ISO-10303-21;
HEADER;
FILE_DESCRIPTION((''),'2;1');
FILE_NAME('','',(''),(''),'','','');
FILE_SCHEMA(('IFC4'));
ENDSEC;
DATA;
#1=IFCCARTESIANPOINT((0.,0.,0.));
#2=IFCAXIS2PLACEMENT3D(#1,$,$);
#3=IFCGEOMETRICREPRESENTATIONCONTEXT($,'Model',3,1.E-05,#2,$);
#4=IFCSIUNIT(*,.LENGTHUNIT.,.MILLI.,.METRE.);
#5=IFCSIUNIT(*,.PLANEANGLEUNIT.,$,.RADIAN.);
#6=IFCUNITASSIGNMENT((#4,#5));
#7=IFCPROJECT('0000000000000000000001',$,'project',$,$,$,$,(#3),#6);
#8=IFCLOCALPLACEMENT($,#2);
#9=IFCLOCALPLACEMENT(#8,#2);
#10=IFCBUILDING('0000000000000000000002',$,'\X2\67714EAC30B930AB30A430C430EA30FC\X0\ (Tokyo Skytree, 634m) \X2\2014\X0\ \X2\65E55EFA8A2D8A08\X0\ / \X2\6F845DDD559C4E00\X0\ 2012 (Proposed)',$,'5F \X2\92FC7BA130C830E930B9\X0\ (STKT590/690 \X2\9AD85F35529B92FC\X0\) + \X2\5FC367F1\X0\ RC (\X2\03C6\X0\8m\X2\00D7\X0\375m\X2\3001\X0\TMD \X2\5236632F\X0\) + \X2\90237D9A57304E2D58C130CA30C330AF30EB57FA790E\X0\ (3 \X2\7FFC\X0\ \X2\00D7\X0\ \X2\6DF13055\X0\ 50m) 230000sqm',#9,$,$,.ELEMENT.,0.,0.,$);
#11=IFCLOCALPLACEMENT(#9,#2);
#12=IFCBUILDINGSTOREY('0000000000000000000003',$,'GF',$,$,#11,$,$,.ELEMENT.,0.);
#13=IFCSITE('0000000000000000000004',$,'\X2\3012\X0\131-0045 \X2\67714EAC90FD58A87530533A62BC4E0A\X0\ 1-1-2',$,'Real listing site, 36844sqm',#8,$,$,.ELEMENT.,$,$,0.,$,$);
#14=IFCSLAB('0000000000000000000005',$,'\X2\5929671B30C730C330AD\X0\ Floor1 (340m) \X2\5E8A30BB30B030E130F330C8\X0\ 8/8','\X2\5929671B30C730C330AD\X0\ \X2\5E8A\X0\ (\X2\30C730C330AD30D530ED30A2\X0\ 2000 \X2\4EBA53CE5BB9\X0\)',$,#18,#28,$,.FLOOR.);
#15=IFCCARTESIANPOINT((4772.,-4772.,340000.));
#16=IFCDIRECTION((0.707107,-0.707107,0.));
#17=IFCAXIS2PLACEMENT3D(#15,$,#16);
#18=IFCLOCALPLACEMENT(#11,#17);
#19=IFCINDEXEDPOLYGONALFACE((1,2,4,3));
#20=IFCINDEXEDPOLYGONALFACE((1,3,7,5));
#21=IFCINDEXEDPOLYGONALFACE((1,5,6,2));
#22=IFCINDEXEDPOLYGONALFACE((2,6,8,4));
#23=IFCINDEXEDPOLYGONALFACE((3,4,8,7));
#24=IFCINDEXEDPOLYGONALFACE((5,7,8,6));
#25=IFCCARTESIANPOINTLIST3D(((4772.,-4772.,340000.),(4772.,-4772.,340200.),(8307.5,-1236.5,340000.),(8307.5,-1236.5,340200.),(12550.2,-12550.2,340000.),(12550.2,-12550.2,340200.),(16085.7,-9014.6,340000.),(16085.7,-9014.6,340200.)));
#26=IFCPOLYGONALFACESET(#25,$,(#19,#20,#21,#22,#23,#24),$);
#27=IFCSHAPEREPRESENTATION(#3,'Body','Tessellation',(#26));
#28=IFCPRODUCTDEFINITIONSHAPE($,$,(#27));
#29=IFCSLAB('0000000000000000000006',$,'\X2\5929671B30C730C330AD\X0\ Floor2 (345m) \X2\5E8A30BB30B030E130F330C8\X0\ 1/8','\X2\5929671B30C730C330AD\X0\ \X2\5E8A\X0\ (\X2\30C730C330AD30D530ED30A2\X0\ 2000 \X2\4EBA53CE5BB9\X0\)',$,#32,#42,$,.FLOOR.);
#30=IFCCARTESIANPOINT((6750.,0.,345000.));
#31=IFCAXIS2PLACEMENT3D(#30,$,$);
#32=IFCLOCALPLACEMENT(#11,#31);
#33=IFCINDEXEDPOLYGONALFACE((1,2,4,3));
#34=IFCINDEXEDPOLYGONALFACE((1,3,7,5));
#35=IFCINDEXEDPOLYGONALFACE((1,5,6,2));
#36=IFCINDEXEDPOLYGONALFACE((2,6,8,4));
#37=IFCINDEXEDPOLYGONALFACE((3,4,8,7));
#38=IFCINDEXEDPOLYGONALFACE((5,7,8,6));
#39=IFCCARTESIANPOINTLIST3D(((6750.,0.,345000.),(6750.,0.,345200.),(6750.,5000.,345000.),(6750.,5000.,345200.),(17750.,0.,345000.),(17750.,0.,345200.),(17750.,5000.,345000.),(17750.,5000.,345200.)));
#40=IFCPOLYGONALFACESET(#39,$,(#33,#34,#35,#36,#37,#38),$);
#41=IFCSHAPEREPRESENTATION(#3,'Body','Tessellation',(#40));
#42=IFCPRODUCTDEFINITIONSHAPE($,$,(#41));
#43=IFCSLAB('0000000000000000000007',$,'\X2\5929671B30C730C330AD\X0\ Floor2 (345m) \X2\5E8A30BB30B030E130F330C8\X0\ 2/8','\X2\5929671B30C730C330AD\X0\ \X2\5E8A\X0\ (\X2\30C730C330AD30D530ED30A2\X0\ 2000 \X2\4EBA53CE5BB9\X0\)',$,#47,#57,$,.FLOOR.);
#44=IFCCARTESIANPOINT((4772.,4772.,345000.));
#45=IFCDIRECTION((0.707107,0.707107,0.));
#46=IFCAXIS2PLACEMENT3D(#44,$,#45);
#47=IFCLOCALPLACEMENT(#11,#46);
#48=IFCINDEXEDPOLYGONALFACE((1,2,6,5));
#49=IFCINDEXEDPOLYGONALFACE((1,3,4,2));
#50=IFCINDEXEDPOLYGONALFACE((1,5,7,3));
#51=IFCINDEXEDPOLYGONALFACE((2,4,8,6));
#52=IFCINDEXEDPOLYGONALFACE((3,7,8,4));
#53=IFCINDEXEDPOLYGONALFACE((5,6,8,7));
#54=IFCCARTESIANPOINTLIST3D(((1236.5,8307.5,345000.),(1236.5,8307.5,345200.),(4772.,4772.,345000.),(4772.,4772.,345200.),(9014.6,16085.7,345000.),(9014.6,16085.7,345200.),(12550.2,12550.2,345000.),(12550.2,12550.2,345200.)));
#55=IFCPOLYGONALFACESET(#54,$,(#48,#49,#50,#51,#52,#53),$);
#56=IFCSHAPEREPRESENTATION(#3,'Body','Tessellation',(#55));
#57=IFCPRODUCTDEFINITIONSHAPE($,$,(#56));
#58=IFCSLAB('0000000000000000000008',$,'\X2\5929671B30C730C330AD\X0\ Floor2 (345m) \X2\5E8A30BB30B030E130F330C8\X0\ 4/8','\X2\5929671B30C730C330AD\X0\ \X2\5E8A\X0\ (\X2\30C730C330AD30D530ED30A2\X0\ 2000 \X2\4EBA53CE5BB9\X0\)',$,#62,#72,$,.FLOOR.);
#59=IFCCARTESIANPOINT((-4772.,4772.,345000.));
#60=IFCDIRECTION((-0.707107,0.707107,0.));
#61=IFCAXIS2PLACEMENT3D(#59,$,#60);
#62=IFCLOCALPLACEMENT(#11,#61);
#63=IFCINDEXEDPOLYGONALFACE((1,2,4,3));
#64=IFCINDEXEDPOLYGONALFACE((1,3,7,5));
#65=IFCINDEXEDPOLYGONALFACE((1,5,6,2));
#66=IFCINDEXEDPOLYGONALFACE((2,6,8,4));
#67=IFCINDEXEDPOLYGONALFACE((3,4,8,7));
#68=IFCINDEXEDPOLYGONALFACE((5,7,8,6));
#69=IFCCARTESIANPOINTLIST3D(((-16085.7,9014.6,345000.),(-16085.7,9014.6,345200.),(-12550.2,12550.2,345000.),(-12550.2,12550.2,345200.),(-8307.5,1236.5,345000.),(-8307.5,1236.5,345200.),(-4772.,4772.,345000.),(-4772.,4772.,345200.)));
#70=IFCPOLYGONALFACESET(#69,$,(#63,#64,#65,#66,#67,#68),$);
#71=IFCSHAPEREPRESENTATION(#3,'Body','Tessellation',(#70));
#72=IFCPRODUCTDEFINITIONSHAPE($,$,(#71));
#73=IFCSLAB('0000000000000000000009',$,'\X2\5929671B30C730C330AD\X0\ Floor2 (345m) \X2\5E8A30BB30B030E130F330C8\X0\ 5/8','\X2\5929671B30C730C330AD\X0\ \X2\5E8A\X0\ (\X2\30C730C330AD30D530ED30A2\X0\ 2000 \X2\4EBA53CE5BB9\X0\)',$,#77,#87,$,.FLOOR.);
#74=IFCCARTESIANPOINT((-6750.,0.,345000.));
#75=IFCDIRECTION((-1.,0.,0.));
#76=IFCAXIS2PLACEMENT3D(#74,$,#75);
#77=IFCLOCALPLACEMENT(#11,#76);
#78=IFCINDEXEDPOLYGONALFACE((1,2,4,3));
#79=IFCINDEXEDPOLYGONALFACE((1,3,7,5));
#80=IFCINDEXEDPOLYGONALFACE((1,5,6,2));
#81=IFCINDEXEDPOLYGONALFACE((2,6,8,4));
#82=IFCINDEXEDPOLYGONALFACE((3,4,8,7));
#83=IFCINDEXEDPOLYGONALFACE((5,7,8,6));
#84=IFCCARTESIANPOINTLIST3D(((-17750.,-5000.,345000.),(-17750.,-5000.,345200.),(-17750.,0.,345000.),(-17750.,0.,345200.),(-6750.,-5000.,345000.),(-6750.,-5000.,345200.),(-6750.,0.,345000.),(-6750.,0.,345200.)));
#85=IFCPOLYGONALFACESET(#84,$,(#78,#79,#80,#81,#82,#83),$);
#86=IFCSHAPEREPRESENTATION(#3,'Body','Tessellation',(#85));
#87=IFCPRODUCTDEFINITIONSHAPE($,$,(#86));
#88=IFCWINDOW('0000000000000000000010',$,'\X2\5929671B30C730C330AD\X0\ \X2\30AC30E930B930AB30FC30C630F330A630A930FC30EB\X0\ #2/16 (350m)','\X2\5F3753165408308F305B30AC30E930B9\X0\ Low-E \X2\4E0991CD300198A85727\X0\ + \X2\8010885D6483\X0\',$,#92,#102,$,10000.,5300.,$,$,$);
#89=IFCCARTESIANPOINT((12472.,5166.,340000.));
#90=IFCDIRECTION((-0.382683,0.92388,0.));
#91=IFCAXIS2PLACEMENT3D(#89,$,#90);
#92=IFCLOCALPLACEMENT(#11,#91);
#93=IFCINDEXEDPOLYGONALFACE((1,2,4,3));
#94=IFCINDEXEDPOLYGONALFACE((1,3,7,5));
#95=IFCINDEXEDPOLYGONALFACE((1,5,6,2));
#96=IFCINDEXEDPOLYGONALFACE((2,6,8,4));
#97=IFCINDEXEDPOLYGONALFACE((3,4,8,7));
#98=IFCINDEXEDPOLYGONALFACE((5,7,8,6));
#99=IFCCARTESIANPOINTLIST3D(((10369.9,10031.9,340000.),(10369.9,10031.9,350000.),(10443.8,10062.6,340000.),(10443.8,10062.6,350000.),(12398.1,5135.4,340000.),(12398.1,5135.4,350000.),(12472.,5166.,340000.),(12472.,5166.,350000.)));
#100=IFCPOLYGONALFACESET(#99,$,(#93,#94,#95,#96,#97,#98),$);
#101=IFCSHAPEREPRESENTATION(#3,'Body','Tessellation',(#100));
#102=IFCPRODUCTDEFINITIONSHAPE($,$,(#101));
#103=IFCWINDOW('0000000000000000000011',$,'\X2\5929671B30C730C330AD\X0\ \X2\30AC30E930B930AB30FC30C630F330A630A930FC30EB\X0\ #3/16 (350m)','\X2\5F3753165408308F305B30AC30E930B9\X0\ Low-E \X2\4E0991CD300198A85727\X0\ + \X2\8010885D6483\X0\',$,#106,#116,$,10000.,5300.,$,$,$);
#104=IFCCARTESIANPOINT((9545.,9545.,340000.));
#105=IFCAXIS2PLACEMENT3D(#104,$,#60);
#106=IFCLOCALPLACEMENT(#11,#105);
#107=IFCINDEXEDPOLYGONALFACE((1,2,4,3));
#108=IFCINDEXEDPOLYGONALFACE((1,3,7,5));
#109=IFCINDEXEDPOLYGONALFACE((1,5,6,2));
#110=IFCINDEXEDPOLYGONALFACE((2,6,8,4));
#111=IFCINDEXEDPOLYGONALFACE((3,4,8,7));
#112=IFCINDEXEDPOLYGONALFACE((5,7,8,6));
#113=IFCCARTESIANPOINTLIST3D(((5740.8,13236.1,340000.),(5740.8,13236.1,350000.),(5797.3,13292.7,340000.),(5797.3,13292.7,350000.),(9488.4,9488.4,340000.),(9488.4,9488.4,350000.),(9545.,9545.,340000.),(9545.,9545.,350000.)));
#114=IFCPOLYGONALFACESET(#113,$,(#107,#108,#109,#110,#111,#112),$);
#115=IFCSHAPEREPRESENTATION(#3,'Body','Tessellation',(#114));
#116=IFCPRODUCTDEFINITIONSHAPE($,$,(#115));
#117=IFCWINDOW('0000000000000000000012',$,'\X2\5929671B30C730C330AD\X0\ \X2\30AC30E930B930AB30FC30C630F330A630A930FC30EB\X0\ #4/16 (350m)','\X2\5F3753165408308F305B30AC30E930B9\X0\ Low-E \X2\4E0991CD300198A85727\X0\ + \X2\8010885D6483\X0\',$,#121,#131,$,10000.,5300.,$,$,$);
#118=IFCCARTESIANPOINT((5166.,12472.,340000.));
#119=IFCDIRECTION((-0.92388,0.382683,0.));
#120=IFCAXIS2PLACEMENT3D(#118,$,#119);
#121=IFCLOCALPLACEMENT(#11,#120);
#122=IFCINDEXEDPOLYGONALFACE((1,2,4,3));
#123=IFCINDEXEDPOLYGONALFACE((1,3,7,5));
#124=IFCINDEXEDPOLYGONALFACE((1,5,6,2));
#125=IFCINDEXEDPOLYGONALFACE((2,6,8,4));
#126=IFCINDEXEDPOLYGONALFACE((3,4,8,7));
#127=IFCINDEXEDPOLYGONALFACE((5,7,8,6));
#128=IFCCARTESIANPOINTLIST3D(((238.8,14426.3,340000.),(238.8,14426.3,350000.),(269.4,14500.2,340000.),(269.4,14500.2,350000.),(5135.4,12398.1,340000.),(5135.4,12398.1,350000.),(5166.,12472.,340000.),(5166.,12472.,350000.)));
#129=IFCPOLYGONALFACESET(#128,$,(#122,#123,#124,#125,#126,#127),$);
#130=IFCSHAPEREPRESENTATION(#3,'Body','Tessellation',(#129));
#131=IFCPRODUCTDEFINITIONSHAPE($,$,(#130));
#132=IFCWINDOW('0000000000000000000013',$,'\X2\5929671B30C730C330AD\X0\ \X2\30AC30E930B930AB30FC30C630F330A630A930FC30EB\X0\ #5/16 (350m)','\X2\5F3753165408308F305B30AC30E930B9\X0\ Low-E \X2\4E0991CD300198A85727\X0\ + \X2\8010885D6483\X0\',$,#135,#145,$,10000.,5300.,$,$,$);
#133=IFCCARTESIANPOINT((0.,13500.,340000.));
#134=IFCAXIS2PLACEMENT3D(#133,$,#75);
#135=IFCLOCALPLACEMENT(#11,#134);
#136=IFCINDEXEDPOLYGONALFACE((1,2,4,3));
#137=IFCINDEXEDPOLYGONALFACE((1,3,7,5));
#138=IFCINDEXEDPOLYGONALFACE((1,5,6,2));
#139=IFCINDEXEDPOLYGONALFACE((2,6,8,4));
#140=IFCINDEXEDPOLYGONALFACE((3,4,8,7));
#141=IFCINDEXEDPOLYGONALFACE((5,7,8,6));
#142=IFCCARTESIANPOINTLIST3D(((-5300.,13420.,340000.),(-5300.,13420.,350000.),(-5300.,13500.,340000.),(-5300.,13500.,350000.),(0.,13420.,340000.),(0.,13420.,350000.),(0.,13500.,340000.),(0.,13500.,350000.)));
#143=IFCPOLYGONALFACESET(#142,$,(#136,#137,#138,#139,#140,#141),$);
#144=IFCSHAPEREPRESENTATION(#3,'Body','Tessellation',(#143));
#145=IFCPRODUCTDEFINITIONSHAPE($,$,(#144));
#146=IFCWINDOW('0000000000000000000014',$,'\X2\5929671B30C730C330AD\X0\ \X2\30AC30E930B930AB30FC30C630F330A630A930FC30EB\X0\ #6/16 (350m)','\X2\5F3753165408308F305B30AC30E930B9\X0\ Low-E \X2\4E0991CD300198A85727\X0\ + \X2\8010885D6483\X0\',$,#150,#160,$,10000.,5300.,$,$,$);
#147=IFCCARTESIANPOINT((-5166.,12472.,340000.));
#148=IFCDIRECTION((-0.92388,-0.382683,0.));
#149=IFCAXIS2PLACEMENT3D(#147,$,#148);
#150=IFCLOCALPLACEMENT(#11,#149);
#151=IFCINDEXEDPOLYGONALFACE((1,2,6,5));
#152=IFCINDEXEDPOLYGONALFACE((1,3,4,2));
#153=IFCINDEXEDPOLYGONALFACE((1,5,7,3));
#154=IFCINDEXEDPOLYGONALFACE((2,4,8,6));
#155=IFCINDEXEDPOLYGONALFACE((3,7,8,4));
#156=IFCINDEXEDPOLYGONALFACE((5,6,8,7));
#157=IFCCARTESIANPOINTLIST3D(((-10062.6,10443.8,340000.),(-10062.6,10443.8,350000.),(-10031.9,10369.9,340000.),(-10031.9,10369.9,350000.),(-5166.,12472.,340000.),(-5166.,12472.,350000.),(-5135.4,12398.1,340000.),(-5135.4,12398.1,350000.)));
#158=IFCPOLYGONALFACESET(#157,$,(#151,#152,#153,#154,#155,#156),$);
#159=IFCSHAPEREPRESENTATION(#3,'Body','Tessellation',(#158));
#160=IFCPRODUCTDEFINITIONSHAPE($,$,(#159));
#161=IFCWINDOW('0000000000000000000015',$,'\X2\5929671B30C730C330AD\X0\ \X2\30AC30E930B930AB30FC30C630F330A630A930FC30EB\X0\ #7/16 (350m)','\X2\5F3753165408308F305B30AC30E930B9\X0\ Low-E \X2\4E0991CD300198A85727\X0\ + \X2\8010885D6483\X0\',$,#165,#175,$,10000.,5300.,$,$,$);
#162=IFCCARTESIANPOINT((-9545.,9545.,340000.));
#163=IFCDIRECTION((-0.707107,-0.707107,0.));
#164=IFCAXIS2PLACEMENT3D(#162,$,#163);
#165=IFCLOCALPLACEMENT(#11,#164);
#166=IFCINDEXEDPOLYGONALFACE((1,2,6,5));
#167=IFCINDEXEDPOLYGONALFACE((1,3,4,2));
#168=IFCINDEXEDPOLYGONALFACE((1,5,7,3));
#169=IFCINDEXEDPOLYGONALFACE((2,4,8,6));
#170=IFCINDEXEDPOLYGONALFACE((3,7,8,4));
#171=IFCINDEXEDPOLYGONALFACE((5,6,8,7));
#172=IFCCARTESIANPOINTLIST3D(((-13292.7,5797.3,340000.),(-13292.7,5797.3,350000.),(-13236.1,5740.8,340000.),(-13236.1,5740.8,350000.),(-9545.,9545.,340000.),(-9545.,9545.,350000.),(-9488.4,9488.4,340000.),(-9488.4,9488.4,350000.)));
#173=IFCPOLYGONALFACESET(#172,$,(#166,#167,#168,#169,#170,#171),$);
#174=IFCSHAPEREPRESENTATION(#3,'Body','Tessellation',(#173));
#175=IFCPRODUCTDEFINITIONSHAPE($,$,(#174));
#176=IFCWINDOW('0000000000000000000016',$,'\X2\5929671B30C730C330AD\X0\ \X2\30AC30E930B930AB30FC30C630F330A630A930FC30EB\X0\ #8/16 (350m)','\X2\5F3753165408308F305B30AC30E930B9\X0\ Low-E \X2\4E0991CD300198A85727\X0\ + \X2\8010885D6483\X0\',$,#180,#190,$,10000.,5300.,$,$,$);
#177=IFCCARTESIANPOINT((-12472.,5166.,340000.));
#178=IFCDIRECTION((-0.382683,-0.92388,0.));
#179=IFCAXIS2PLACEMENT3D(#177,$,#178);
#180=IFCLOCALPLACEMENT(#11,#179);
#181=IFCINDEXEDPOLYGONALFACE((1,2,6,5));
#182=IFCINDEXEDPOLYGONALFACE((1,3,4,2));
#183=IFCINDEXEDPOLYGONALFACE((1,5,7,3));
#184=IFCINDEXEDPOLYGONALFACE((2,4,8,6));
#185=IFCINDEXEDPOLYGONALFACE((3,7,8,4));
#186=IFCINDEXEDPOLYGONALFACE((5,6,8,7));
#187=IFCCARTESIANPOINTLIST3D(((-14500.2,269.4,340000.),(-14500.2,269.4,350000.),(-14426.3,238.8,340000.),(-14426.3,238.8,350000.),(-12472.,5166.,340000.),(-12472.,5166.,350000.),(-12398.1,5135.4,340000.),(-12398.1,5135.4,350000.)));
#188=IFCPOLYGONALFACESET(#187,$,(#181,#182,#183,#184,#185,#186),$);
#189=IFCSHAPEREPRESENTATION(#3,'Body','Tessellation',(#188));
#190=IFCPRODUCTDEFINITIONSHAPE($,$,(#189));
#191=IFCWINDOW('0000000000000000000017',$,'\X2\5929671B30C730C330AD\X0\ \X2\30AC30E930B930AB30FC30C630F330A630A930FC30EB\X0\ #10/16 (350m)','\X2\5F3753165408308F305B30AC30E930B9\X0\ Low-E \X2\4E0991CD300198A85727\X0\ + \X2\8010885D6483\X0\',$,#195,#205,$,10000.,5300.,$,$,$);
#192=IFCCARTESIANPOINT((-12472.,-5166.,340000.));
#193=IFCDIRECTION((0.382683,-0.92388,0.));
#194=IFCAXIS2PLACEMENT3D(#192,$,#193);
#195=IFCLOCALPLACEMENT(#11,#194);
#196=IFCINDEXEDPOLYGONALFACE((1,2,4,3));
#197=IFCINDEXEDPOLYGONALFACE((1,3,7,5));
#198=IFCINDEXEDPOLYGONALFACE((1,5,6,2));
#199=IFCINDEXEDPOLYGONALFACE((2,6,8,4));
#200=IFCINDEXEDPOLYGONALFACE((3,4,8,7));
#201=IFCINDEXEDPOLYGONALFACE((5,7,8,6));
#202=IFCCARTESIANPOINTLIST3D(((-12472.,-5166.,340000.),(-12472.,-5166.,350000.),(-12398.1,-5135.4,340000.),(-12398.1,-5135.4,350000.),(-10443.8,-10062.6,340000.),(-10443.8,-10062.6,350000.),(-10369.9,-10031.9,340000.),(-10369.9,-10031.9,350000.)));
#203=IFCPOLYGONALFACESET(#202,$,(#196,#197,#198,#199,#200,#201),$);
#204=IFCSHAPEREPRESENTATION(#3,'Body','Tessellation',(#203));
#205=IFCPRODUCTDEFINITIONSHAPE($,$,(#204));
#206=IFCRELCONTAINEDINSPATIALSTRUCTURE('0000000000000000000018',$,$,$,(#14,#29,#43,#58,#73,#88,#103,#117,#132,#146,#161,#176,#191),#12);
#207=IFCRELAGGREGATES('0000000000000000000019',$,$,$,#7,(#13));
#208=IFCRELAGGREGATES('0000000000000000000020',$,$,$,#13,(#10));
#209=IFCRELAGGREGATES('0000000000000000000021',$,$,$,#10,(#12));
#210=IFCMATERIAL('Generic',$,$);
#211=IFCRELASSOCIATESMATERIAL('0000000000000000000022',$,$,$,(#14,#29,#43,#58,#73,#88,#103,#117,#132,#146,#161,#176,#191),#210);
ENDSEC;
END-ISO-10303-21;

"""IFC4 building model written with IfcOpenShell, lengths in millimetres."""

from ifc_helpers import new_model, si_unit, frame, frame_2d, origin, place, context, project, spatial, rectangle, extrude, material, element, save


model = new_model("IFC4")

# Units and contexts
model_context = context("Model", 3, precision=1e-05, world=origin())
ifc_project = project(units=[si_unit("LENGTHUNIT", "METRE", prefix="MILLI"), si_unit("PLANEANGLEUNIT", "RADIAN")], contexts=[model_context])

# Site, building, storey
site_placement = place(None, origin())
site = spatial("IfcSite", under=ifc_project, at=site_placement, Name="〒131-0045 東京都墨田区押上 1-1-2", ObjectType="Real listing site, 36844sqm", CompositionType="ELEMENT", RefElevation=0.0)
building_placement = place(site_placement, origin())
building = spatial("IfcBuilding", under=site, at=building_placement, Name="東京スカイツリー (Tokyo Skytree, 634m) — 日建設計 / 澄川喜一 2012 (Proposed)", ObjectType="5F 鋼管トラス (STKT590/690 高張力鋼) + 心柱 RC (φ8m×375m、TMD 制振) + 連続地中壁ナックル基礎 (3 翼 × 深さ 50m) 230000sqm", CompositionType="ELEMENT", ElevationOfRefHeight=0.0, ElevationOfTerrain=0.0)
storey_placement = place(building_placement, origin())
storey = spatial("IfcBuildingStorey", under=building, at=storey_placement, Name="GF", CompositionType="ELEMENT", Elevation=0.0)

# Slabs
ifc_material = material(Name="Generic")
slab_1_placement = place(storey_placement, frame((4772.0, -4772.0, 340000.0), x_axis=(0.707107, -0.707107, 0.0)))
element("IfcSlab", 1, at=slab_1_placement, inside=storey, material=ifc_material, Name="天望デッキ Floor1 (340m) 床セグメント 8/8", Description="天望デッキ 床 (デッキフロア 2000 人収容)", PredefinedType="FLOOR", context=model_context, shape_type="SweptSolid", body=[
    extrude(rectangle(XDim=11000.0, YDim=5000.0, at=frame_2d((5500.0, 2500.0))), frame((4772.0, -4772.0, 340000.0), x_axis=(0.707107, -0.707107, 0.0)), (0.0, 0.0, 1.0), 200.0),
])
slab_2_placement = place(storey_placement, frame((6750.0, 0.0, 345000.0)))
element("IfcSlab", 2, at=slab_2_placement, inside=storey, material=ifc_material, Name="天望デッキ Floor2 (345m) 床セグメント 1/8", Description="天望デッキ 床 (デッキフロア 2000 人収容)", PredefinedType="FLOOR", context=model_context, shape_type="SweptSolid", body=[
    extrude(rectangle(XDim=11000.0, YDim=5000.0, at=frame_2d((5500.0, 2500.0))), frame((6750.0, 0.0, 345000.0)), (0.0, 0.0, 1.0), 200.0),
])
slab_3_placement = place(storey_placement, frame((4772.0, 4772.0, 345000.0), x_axis=(0.707107, 0.707107, 0.0)))
element("IfcSlab", 3, at=slab_3_placement, inside=storey, material=ifc_material, Name="天望デッキ Floor2 (345m) 床セグメント 2/8", Description="天望デッキ 床 (デッキフロア 2000 人収容)", PredefinedType="FLOOR", context=model_context, shape_type="SweptSolid", body=[
    extrude(rectangle(XDim=11000.0, YDim=5000.0, at=frame_2d((5500.0, 2500.0))), frame((4772.0, 4772.0, 345000.0), x_axis=(0.707107, 0.707107, 0.0)), (0.0, 0.0, 1.0), 200.0),
])
slab_4_placement = place(storey_placement, frame((-4772.0, 4772.0, 345000.0), x_axis=(-0.707107, 0.707107, 0.0)))
element("IfcSlab", 4, at=slab_4_placement, inside=storey, material=ifc_material, Name="天望デッキ Floor2 (345m) 床セグメント 4/8", Description="天望デッキ 床 (デッキフロア 2000 人収容)", PredefinedType="FLOOR", context=model_context, shape_type="SweptSolid", body=[
    extrude(rectangle(XDim=11000.0, YDim=5000.0, at=frame_2d((5500.0, 2500.0))), frame((-4772.0, 4772.0, 345000.0), x_axis=(-0.707107, 0.707107, 0.0)), (0.0, 0.0, 1.0), 200.0),
])
slab_5_placement = place(storey_placement, frame((-6750.0, 0.0, 345000.0), x_axis=(-1.0, 0.0, 0.0)))
element("IfcSlab", 5, at=slab_5_placement, inside=storey, material=ifc_material, Name="天望デッキ Floor2 (345m) 床セグメント 5/8", Description="天望デッキ 床 (デッキフロア 2000 人収容)", PredefinedType="FLOOR", context=model_context, shape_type="SweptSolid", body=[
    extrude(rectangle(XDim=11000.0, YDim=5000.0, at=frame_2d((5500.0, 2500.0))), frame((-6750.0, 0.0, 345000.0), x_axis=(-1.0, 0.0, 0.0)), (0.0, 0.0, 1.0), 200.0),
])

# Windows
window_1_placement = place(storey_placement, frame((12472.0, 5166.0, 340000.0), x_axis=(-0.382683, 0.92388, 0.0)))
element("IfcWindow", 6, at=window_1_placement, inside=storey, material=ifc_material, Name="天望デッキ ガラスカーテンウォール #2/16 (350m)", Description="強化合わせガラス Low-E 三重、風圧 + 耐衝撃", OverallHeight=10000.0, OverallWidth=5300.0, context=model_context, shape_type="SweptSolid", body=[
    extrude(rectangle(XDim=5300.0, YDim=80.0, at=frame_2d((2650.0, 40.0))), frame((12472.0, 5166.0, 340000.0), x_axis=(-0.382683, 0.92388, 0.0)), (0.0, 0.0, 1.0), 10000.0),
])
window_2_placement = place(storey_placement, frame((9545.0, 9545.0, 340000.0), x_axis=(-0.707107, 0.707107, 0.0)))
element("IfcWindow", 7, at=window_2_placement, inside=storey, material=ifc_material, Name="天望デッキ ガラスカーテンウォール #3/16 (350m)", Description="強化合わせガラス Low-E 三重、風圧 + 耐衝撃", OverallHeight=10000.0, OverallWidth=5300.0, context=model_context, shape_type="SweptSolid", body=[
    extrude(rectangle(XDim=5300.0, YDim=80.0, at=frame_2d((2650.0, 40.0))), frame((9545.0, 9545.0, 340000.0), x_axis=(-0.707107, 0.707107, 0.0)), (0.0, 0.0, 1.0), 10000.0),
])
window_3_placement = place(storey_placement, frame((5166.0, 12472.0, 340000.0), x_axis=(-0.92388, 0.382683, 0.0)))
element("IfcWindow", 8, at=window_3_placement, inside=storey, material=ifc_material, Name="天望デッキ ガラスカーテンウォール #4/16 (350m)", Description="強化合わせガラス Low-E 三重、風圧 + 耐衝撃", OverallHeight=10000.0, OverallWidth=5300.0, context=model_context, shape_type="SweptSolid", body=[
    extrude(rectangle(XDim=5300.0, YDim=80.0, at=frame_2d((2650.0, 40.0))), frame((5166.0, 12472.0, 340000.0), x_axis=(-0.92388, 0.382683, 0.0)), (0.0, 0.0, 1.0), 10000.0),
])
window_4_placement = place(storey_placement, frame((0.0, 13500.0, 340000.0), x_axis=(-1.0, 0.0, 0.0)))
element("IfcWindow", 9, at=window_4_placement, inside=storey, material=ifc_material, Name="天望デッキ ガラスカーテンウォール #5/16 (350m)", Description="強化合わせガラス Low-E 三重、風圧 + 耐衝撃", OverallHeight=10000.0, OverallWidth=5300.0, context=model_context, shape_type="SweptSolid", body=[
    extrude(rectangle(XDim=5300.0, YDim=80.0, at=frame_2d((2650.0, 40.0))), frame((0.0, 13500.0, 340000.0), x_axis=(-1.0, 0.0, 0.0)), (0.0, 0.0, 1.0), 10000.0),
])
window_5_placement = place(storey_placement, frame((-5166.0, 12472.0, 340000.0), x_axis=(-0.92388, -0.382683, 0.0)))
element("IfcWindow", 10, at=window_5_placement, inside=storey, material=ifc_material, Name="天望デッキ ガラスカーテンウォール #6/16 (350m)", Description="強化合わせガラス Low-E 三重、風圧 + 耐衝撃", OverallHeight=10000.0, OverallWidth=5300.0, context=model_context, shape_type="SweptSolid", body=[
    extrude(rectangle(XDim=5300.0, YDim=80.0, at=frame_2d((2650.0, 40.0))), frame((-5166.0, 12472.0, 340000.0), x_axis=(-0.92388, -0.382683, 0.0)), (0.0, 0.0, 1.0), 10000.0),
])
window_6_placement = place(storey_placement, frame((-9545.0, 9545.0, 340000.0), x_axis=(-0.707107, -0.707107, 0.0)))
element("IfcWindow", 11, at=window_6_placement, inside=storey, material=ifc_material, Name="天望デッキ ガラスカーテンウォール #7/16 (350m)", Description="強化合わせガラス Low-E 三重、風圧 + 耐衝撃", OverallHeight=10000.0, OverallWidth=5300.0, context=model_context, shape_type="SweptSolid", body=[
    extrude(rectangle(XDim=5300.0, YDim=80.0, at=frame_2d((2650.0, 40.0))), frame((-9545.0, 9545.0, 340000.0), x_axis=(-0.707107, -0.707107, 0.0)), (0.0, 0.0, 1.0), 10000.0),
])
window_7_placement = place(storey_placement, frame((-12472.0, 5166.0, 340000.0), x_axis=(-0.382683, -0.92388, 0.0)))
element("IfcWindow", 12, at=window_7_placement, inside=storey, material=ifc_material, Name="天望デッキ ガラスカーテンウォール #8/16 (350m)", Description="強化合わせガラス Low-E 三重、風圧 + 耐衝撃", OverallHeight=10000.0, OverallWidth=5300.0, context=model_context, shape_type="SweptSolid", body=[
    extrude(rectangle(XDim=5300.0, YDim=80.0, at=frame_2d((2650.0, 40.0))), frame((-12472.0, 5166.0, 340000.0), x_axis=(-0.382683, -0.92388, 0.0)), (0.0, 0.0, 1.0), 10000.0),
])
window_8_placement = place(storey_placement, frame((-12472.0, -5166.0, 340000.0), x_axis=(0.382683, -0.92388, 0.0)))
element("IfcWindow", 13, at=window_8_placement, inside=storey, material=ifc_material, Name="天望デッキ ガラスカーテンウォール #10/16 (350m)", Description="強化合わせガラス Low-E 三重、風圧 + 耐衝撃", OverallHeight=10000.0, OverallWidth=5300.0, context=model_context, shape_type="SweptSolid", body=[
    extrude(rectangle(XDim=5300.0, YDim=80.0, at=frame_2d((2650.0, 40.0))), frame((-12472.0, -5166.0, 340000.0), x_axis=(0.382683, -0.92388, 0.0)), (0.0, 0.0, 1.0), 10000.0),
])

save(model, "model.ifc")
